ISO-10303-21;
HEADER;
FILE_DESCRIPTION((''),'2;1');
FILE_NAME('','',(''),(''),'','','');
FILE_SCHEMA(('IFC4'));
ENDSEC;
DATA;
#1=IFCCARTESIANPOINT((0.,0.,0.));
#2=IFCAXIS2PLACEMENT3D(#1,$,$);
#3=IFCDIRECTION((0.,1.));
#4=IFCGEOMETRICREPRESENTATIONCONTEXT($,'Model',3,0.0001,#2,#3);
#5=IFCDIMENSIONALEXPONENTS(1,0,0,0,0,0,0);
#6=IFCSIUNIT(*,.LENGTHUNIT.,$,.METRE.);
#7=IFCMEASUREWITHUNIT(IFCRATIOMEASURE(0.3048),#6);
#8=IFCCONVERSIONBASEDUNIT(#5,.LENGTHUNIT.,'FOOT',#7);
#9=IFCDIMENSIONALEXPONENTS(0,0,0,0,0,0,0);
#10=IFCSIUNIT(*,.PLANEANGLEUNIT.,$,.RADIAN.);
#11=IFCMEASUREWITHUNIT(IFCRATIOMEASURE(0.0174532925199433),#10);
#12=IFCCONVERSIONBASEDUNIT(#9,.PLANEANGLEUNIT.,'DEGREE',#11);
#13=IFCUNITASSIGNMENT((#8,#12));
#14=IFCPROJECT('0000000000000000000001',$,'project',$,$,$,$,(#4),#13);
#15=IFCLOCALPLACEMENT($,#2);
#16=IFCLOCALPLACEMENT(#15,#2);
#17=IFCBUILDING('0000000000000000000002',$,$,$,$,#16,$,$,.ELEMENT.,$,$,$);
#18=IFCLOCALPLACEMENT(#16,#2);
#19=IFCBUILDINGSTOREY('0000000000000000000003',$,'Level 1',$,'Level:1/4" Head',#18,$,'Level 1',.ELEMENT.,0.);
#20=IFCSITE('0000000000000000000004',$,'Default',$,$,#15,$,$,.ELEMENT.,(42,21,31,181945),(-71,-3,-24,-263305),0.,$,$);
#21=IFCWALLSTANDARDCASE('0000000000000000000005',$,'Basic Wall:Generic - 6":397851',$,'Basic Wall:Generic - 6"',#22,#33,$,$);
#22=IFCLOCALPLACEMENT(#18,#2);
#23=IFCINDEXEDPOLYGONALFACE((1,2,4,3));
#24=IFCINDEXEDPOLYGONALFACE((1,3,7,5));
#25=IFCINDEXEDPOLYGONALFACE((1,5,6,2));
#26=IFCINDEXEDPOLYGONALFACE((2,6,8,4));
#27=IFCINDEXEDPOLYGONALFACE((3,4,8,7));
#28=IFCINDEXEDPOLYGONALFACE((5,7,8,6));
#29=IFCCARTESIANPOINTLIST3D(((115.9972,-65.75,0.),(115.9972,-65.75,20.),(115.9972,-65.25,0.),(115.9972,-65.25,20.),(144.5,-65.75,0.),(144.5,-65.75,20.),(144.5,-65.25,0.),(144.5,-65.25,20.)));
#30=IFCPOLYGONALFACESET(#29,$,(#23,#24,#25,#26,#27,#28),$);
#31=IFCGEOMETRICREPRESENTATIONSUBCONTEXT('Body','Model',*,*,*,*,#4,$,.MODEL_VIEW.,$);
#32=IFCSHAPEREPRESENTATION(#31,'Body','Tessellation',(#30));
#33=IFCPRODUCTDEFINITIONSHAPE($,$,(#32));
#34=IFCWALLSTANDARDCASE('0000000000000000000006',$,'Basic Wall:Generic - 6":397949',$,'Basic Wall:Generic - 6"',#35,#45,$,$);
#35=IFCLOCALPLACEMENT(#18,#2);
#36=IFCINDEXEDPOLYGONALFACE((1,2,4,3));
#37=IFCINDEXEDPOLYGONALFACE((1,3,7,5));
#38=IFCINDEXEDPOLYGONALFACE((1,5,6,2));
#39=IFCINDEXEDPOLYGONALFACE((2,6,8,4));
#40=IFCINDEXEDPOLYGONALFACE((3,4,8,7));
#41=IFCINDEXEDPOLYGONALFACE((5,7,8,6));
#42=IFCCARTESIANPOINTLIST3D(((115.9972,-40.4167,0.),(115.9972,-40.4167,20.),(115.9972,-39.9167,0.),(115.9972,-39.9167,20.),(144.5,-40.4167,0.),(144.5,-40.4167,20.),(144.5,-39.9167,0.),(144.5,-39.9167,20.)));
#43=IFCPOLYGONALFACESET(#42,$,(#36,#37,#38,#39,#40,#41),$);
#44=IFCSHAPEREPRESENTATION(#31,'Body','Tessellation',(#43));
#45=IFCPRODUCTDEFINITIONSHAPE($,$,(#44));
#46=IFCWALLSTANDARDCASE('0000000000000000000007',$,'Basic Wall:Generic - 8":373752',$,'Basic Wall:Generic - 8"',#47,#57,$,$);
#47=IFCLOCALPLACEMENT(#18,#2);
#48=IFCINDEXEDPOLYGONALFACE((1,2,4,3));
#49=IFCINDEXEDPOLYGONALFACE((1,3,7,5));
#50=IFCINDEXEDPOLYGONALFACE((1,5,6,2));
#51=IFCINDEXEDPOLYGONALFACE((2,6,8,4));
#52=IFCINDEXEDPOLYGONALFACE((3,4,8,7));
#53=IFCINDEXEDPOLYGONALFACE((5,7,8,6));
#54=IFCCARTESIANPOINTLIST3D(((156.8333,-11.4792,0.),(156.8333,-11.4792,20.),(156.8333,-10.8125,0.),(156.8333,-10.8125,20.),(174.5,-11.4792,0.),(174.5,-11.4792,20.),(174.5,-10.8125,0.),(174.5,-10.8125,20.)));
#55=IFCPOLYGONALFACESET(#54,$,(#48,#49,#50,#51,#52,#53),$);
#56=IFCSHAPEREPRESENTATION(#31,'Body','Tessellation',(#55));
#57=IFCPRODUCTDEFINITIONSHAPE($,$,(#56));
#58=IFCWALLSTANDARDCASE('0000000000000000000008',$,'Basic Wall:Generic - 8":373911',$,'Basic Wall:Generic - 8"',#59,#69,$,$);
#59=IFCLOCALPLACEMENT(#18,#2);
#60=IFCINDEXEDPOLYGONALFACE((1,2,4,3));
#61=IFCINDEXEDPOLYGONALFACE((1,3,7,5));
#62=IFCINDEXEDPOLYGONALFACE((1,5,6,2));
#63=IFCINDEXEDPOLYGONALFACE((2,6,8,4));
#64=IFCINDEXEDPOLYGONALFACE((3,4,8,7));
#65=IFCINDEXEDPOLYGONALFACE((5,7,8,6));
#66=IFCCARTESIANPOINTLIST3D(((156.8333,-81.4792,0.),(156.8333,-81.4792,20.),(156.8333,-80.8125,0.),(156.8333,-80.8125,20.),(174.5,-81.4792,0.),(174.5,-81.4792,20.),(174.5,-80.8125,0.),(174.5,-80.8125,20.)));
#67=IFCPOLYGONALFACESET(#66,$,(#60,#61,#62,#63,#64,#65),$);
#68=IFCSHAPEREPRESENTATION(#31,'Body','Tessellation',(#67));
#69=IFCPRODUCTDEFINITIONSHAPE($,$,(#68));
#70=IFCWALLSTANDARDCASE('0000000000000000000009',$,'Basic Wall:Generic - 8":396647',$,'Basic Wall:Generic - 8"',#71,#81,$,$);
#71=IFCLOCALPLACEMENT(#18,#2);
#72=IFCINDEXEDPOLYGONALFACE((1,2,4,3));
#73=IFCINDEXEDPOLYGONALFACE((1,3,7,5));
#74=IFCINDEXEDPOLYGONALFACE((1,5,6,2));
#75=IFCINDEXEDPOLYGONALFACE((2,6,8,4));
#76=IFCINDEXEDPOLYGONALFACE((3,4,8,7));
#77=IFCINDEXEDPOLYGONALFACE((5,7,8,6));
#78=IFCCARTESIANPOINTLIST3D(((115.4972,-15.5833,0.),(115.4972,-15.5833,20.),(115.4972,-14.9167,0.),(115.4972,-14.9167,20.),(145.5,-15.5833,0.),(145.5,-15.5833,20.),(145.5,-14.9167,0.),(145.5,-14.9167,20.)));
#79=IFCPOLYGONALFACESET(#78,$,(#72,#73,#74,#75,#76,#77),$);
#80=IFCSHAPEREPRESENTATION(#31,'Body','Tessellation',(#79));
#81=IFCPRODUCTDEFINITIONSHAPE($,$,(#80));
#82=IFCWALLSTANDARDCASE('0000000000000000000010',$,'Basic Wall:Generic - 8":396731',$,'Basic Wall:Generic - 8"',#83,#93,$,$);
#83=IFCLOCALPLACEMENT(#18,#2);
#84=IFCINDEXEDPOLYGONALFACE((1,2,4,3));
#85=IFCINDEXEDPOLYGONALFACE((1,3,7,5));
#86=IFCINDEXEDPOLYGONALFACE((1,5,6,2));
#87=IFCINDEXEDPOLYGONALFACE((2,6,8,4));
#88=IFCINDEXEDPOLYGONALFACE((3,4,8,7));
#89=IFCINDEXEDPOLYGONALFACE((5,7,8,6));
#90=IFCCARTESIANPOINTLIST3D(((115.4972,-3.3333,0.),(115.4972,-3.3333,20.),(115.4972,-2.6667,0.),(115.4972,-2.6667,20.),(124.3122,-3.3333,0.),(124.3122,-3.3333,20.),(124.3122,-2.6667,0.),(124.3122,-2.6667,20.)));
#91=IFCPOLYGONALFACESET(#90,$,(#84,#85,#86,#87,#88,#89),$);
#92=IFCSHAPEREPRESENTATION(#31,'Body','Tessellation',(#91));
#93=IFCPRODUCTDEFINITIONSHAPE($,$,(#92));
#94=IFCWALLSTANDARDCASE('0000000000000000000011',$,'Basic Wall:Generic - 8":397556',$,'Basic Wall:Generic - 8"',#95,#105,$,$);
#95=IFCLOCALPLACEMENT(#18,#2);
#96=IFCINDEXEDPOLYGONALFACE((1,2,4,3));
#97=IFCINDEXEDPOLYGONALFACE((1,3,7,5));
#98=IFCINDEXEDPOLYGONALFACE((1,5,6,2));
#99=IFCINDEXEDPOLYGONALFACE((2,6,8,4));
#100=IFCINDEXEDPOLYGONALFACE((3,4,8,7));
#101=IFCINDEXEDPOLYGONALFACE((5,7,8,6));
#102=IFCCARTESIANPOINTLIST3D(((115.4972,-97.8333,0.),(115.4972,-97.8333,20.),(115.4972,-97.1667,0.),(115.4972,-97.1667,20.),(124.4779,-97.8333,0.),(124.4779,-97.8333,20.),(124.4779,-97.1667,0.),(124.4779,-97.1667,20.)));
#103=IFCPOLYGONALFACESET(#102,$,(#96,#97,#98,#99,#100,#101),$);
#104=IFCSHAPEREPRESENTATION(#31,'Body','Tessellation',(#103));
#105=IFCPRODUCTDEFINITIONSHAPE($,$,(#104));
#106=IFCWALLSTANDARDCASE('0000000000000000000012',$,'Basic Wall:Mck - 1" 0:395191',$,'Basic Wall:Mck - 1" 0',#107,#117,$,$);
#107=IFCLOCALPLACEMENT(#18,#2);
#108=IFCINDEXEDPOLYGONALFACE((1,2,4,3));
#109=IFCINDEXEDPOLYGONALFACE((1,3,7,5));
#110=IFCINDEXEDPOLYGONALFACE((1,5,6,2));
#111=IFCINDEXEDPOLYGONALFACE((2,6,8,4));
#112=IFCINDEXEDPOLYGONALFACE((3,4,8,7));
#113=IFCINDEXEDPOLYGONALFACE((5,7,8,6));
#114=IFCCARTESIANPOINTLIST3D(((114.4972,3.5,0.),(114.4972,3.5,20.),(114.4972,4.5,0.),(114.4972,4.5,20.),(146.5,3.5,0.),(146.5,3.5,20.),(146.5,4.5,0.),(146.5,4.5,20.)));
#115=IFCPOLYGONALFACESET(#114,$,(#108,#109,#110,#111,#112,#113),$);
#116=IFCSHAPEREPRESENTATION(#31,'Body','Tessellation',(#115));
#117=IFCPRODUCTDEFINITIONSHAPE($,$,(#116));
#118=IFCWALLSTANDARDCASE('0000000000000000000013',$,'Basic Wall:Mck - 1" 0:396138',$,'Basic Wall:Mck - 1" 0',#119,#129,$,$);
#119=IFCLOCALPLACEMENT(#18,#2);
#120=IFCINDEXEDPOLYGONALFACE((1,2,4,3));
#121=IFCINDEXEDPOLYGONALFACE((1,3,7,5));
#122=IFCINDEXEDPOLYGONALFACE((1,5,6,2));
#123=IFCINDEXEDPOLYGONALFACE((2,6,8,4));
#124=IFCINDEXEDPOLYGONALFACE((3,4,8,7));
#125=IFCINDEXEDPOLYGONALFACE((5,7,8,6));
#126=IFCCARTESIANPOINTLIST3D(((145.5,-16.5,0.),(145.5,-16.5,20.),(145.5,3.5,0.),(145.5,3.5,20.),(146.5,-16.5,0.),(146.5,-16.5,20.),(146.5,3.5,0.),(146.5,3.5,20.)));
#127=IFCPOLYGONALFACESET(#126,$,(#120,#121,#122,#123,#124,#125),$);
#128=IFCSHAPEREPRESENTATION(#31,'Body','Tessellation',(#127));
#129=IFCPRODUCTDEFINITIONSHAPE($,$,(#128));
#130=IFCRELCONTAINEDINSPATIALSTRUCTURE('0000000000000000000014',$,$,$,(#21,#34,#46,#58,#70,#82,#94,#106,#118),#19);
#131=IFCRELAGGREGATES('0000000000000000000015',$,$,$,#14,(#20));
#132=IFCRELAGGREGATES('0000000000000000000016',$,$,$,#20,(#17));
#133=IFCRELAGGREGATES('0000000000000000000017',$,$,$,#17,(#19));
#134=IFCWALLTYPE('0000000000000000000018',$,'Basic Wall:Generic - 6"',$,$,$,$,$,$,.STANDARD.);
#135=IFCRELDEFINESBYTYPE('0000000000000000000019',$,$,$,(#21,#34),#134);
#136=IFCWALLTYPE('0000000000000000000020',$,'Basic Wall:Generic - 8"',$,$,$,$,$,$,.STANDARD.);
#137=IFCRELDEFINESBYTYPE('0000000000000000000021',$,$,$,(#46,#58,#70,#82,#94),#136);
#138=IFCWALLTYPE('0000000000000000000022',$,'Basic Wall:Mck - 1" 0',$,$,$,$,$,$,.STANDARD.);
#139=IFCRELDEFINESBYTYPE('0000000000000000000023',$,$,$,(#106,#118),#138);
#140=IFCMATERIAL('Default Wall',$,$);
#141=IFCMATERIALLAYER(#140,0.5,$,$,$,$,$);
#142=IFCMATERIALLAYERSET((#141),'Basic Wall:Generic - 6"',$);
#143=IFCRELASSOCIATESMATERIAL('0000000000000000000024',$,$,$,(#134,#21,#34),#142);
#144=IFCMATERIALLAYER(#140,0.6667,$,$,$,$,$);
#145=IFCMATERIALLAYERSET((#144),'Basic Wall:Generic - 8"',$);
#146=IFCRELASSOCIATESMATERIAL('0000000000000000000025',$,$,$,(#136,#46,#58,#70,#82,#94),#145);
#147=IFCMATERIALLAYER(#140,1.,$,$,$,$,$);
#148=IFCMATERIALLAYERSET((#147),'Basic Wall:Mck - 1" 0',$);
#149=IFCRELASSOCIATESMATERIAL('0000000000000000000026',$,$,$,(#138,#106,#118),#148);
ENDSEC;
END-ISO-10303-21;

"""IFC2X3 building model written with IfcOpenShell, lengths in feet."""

from ifc_helpers import new_model, entity, si_unit, converted_unit, direction, frame, frame_2d, origin, place, context, subcontext, project, spatial, rectangle, extrude, material, layer, layer_set, layer_usage, type_object, element, save


model = new_model("IFC2X3")

# Units and contexts
model_context = context("Model", 3, precision=0.0001, world=origin(), true_north=direction((0.0, 1.0)))
body_context = subcontext(model_context, "Body", "Model", "MODEL_VIEW")
ifc_project = project(units=[converted_unit("LENGTHUNIT", "FOOT", entity("IfcRatioMeasure", 0.3048), si_unit("LENGTHUNIT", "METRE"), dimensions=[1, 0, 0, 0, 0, 0, 0]), converted_unit("PLANEANGLEUNIT", "DEGREE", entity("IfcRatioMeasure", 0.0174532925199433), si_unit("PLANEANGLEUNIT", "RADIAN"), dimensions=[0, 0, 0, 0, 0, 0, 0])], contexts=[model_context])

# Site, building, storey
site_placement = place(None, origin())
site = spatial("IfcSite", under=ifc_project, at=site_placement, Name="Default", CompositionType="ELEMENT", RefLatitude=(42, 21, 31, 181945), RefLongitude=(-71, -3, -24, -263305), RefElevation=0.0)
building_placement = place(site_placement, origin())
building = spatial("IfcBuilding", under=site, at=building_placement, CompositionType="ELEMENT")
storey_placement = place(building_placement, origin())
storey = spatial("IfcBuildingStorey", under=building, at=storey_placement, Name="Level 1", ObjectType="Level:1/4\" Head", LongName="Level 1", CompositionType="ELEMENT", Elevation=0.0)

# Walls
ifc_material = material(Name="Default Wall")
ifc_layer_1 = layer(ifc_material, 0.5)
ifc_layer_set_1 = layer_set([ifc_layer_1], Name="Basic Wall:Generic - 6\"")
wall_type_1 = type_object("IfcWallType", Name="Basic Wall:Generic - 6\"", PredefinedType="STANDARD", material=ifc_layer_set_1)
ifc_layer_usage_1 = layer_usage(ifc_layer_set_1, "AXIS2", "NEGATIVE", 0.25)
wall_1_placement = place(storey_placement, frame((115.9972, -65.5, 0.0)))
element("IfcWallStandardCase", 1, at=wall_1_placement, inside=storey, type_object=wall_type_1, material=ifc_layer_usage_1, Name="Basic Wall:Generic - 6\":397851", ObjectType="Basic Wall:Generic - 6\"", context=body_context, shape_type="SweptSolid", body=[
    extrude(rectangle(XDim=28.5028, YDim=0.5, at=frame_2d((14.2514, 0.0), x_axis=(-1.0, 0.0))), origin(), (0.0, 0.0, 1.0), 20.0),
])
ifc_layer_usage_2 = layer_usage(ifc_layer_set_1, "AXIS2", "NEGATIVE", 0.25)
wall_2_placement = place(storey_placement, frame((115.9972, -40.1667, 0.0)))
element("IfcWallStandardCase", 2, at=wall_2_placement, inside=storey, type_object=wall_type_1, material=ifc_layer_usage_2, Name="Basic Wall:Generic - 6\":397949", ObjectType="Basic Wall:Generic - 6\"", context=body_context, shape_type="SweptSolid", body=[
    extrude(rectangle(XDim=28.5028, YDim=0.5, at=frame_2d((14.2514, 0.0), x_axis=(-1.0, 0.0))), origin(), (0.0, 0.0, 1.0), 20.0),
])
ifc_layer_2 = layer(ifc_material, 0.6667)
ifc_layer_set_2 = layer_set([ifc_layer_2], Name="Basic Wall:Generic - 8\"")
ifc_layer_usage_3 = layer_usage(ifc_layer_set_2, "AXIS2", "NEGATIVE", 0.3333)
wall_type_2 = type_object("IfcWallType", Name="Basic Wall:Generic - 8\"", PredefinedType="STANDARD", material=ifc_layer_set_2)
wall_3_placement = place(storey_placement, frame((156.8333, -11.1458, 0.0)))
element("IfcWallStandardCase", 3, at=wall_3_placement, inside=storey, type_object=wall_type_2, material=ifc_layer_usage_3, Name="Basic Wall:Generic - 8\":373752", ObjectType="Basic Wall:Generic - 8\"", context=body_context, shape_type="SweptSolid", body=[
    extrude(rectangle(XDim=17.6667, YDim=0.6667, at=frame_2d((8.8333, 0.0), x_axis=(-1.0, 0.0))), origin(), (0.0, 0.0, 1.0), 20.0),
])
ifc_layer_usage_4 = layer_usage(ifc_layer_set_2, "AXIS2", "NEGATIVE", 0.3333)
wall_4_placement = place(storey_placement, frame((156.8333, -81.1458, 0.0)))
element("IfcWallStandardCase", 4, at=wall_4_placement, inside=storey, type_object=wall_type_2, material=ifc_layer_usage_4, Name="Basic Wall:Generic - 8\":373911", ObjectType="Basic Wall:Generic - 8\"", context=body_context, shape_type="SweptSolid", body=[
    extrude(rectangle(XDim=17.6667, YDim=0.6667, at=frame_2d((8.8333, 0.0), x_axis=(-1.0, 0.0))), origin(), (0.0, 0.0, 1.0), 20.0),
])
ifc_layer_usage_5 = layer_usage(ifc_layer_set_2, "AXIS2", "NEGATIVE", 0.3333)
wall_5_placement = place(storey_placement, frame((115.4972, -15.25, 0.0)))
element("IfcWallStandardCase", 5, at=wall_5_placement, inside=storey, type_object=wall_type_2, material=ifc_layer_usage_5, Name="Basic Wall:Generic - 8\":396647", ObjectType="Basic Wall:Generic - 8\"", context=body_context, shape_type="SweptSolid", body=[
    extrude(rectangle(XDim=30.0028, YDim=0.6667, at=frame_2d((15.0014, 0.0), x_axis=(-1.0, 0.0))), origin(), (0.0, 0.0, 1.0), 20.0),
])
ifc_layer_usage_6 = layer_usage(ifc_layer_set_2, "AXIS2", "NEGATIVE", 0.3333)
wall_6_placement = place(storey_placement, frame((115.4972, -3.0, 0.0)))
element("IfcWallStandardCase", 6, at=wall_6_placement, inside=storey, type_object=wall_type_2, material=ifc_layer_usage_6, Name="Basic Wall:Generic - 8\":396731", ObjectType="Basic Wall:Generic - 8\"", context=body_context, shape_type="SweptSolid", body=[
    extrude(rectangle(XDim=8.8149, YDim=0.6667, at=frame_2d((4.4075, 0.0), x_axis=(-1.0, 0.0))), origin(), (0.0, 0.0, 1.0), 20.0),
])
ifc_layer_usage_7 = layer_usage(ifc_layer_set_2, "AXIS2", "NEGATIVE", 0.3333)
wall_7_placement = place(storey_placement, frame((115.4972, -97.5, 0.0)))
element("IfcWallStandardCase", 7, at=wall_7_placement, inside=storey, type_object=wall_type_2, material=ifc_layer_usage_7, Name="Basic Wall:Generic - 8\":397556", ObjectType="Basic Wall:Generic - 8\"", context=body_context, shape_type="SweptSolid", body=[
    extrude(rectangle(XDim=8.9806, YDim=0.6667, at=frame_2d((4.4903, 0.0), x_axis=(-1.0, 0.0))), origin(), (0.0, 0.0, 1.0), 20.0),
])
ifc_layer_3 = layer(ifc_material, 1.0)
ifc_layer_set_3 = layer_set([ifc_layer_3], Name="Basic Wall:Mck - 1\" 0")
ifc_layer_usage_8 = layer_usage(ifc_layer_set_3, "AXIS2", "NEGATIVE", 0.5)
wall_type_3 = type_object("IfcWallType", Name="Basic Wall:Mck - 1\" 0", PredefinedType="STANDARD", material=ifc_layer_set_3)
wall_8_placement = place(storey_placement, frame((114.4972, 4.0, 0.0)))
element("IfcWallStandardCase", 8, at=wall_8_placement, inside=storey, type_object=wall_type_3, material=ifc_layer_usage_8, Name="Basic Wall:Mck - 1\" 0:395191", ObjectType="Basic Wall:Mck - 1\" 0", context=body_context, shape_type="SweptSolid", body=[
    extrude(rectangle(XDim=32.0028, YDim=1.0, at=frame_2d((16.0014, 0.0), x_axis=(-1.0, 0.0))), origin(), (0.0, 0.0, 1.0), 20.0),
])
ifc_layer_usage_9 = layer_usage(ifc_layer_set_3, "AXIS2", "NEGATIVE", 0.5)
wall_9_placement = place(storey_placement, frame((146.0, -16.5, 0.0), z_axis=(0.0, 0.0, 1.0), x_axis=(0.0, 1.0, 0.0)))
element("IfcWallStandardCase", 9, at=wall_9_placement, inside=storey, type_object=wall_type_3, material=ifc_layer_usage_9, Name="Basic Wall:Mck - 1\" 0:396138", ObjectType="Basic Wall:Mck - 1\" 0", context=body_context, shape_type="SweptSolid", body=[
    extrude(rectangle(XDim=20.0, YDim=1.0, at=frame_2d((10.0, 0.0), x_axis=(-1.0, 0.0))), origin(), (0.0, 0.0, 1.0), 20.0),
])

save(model, "model.ifc")
